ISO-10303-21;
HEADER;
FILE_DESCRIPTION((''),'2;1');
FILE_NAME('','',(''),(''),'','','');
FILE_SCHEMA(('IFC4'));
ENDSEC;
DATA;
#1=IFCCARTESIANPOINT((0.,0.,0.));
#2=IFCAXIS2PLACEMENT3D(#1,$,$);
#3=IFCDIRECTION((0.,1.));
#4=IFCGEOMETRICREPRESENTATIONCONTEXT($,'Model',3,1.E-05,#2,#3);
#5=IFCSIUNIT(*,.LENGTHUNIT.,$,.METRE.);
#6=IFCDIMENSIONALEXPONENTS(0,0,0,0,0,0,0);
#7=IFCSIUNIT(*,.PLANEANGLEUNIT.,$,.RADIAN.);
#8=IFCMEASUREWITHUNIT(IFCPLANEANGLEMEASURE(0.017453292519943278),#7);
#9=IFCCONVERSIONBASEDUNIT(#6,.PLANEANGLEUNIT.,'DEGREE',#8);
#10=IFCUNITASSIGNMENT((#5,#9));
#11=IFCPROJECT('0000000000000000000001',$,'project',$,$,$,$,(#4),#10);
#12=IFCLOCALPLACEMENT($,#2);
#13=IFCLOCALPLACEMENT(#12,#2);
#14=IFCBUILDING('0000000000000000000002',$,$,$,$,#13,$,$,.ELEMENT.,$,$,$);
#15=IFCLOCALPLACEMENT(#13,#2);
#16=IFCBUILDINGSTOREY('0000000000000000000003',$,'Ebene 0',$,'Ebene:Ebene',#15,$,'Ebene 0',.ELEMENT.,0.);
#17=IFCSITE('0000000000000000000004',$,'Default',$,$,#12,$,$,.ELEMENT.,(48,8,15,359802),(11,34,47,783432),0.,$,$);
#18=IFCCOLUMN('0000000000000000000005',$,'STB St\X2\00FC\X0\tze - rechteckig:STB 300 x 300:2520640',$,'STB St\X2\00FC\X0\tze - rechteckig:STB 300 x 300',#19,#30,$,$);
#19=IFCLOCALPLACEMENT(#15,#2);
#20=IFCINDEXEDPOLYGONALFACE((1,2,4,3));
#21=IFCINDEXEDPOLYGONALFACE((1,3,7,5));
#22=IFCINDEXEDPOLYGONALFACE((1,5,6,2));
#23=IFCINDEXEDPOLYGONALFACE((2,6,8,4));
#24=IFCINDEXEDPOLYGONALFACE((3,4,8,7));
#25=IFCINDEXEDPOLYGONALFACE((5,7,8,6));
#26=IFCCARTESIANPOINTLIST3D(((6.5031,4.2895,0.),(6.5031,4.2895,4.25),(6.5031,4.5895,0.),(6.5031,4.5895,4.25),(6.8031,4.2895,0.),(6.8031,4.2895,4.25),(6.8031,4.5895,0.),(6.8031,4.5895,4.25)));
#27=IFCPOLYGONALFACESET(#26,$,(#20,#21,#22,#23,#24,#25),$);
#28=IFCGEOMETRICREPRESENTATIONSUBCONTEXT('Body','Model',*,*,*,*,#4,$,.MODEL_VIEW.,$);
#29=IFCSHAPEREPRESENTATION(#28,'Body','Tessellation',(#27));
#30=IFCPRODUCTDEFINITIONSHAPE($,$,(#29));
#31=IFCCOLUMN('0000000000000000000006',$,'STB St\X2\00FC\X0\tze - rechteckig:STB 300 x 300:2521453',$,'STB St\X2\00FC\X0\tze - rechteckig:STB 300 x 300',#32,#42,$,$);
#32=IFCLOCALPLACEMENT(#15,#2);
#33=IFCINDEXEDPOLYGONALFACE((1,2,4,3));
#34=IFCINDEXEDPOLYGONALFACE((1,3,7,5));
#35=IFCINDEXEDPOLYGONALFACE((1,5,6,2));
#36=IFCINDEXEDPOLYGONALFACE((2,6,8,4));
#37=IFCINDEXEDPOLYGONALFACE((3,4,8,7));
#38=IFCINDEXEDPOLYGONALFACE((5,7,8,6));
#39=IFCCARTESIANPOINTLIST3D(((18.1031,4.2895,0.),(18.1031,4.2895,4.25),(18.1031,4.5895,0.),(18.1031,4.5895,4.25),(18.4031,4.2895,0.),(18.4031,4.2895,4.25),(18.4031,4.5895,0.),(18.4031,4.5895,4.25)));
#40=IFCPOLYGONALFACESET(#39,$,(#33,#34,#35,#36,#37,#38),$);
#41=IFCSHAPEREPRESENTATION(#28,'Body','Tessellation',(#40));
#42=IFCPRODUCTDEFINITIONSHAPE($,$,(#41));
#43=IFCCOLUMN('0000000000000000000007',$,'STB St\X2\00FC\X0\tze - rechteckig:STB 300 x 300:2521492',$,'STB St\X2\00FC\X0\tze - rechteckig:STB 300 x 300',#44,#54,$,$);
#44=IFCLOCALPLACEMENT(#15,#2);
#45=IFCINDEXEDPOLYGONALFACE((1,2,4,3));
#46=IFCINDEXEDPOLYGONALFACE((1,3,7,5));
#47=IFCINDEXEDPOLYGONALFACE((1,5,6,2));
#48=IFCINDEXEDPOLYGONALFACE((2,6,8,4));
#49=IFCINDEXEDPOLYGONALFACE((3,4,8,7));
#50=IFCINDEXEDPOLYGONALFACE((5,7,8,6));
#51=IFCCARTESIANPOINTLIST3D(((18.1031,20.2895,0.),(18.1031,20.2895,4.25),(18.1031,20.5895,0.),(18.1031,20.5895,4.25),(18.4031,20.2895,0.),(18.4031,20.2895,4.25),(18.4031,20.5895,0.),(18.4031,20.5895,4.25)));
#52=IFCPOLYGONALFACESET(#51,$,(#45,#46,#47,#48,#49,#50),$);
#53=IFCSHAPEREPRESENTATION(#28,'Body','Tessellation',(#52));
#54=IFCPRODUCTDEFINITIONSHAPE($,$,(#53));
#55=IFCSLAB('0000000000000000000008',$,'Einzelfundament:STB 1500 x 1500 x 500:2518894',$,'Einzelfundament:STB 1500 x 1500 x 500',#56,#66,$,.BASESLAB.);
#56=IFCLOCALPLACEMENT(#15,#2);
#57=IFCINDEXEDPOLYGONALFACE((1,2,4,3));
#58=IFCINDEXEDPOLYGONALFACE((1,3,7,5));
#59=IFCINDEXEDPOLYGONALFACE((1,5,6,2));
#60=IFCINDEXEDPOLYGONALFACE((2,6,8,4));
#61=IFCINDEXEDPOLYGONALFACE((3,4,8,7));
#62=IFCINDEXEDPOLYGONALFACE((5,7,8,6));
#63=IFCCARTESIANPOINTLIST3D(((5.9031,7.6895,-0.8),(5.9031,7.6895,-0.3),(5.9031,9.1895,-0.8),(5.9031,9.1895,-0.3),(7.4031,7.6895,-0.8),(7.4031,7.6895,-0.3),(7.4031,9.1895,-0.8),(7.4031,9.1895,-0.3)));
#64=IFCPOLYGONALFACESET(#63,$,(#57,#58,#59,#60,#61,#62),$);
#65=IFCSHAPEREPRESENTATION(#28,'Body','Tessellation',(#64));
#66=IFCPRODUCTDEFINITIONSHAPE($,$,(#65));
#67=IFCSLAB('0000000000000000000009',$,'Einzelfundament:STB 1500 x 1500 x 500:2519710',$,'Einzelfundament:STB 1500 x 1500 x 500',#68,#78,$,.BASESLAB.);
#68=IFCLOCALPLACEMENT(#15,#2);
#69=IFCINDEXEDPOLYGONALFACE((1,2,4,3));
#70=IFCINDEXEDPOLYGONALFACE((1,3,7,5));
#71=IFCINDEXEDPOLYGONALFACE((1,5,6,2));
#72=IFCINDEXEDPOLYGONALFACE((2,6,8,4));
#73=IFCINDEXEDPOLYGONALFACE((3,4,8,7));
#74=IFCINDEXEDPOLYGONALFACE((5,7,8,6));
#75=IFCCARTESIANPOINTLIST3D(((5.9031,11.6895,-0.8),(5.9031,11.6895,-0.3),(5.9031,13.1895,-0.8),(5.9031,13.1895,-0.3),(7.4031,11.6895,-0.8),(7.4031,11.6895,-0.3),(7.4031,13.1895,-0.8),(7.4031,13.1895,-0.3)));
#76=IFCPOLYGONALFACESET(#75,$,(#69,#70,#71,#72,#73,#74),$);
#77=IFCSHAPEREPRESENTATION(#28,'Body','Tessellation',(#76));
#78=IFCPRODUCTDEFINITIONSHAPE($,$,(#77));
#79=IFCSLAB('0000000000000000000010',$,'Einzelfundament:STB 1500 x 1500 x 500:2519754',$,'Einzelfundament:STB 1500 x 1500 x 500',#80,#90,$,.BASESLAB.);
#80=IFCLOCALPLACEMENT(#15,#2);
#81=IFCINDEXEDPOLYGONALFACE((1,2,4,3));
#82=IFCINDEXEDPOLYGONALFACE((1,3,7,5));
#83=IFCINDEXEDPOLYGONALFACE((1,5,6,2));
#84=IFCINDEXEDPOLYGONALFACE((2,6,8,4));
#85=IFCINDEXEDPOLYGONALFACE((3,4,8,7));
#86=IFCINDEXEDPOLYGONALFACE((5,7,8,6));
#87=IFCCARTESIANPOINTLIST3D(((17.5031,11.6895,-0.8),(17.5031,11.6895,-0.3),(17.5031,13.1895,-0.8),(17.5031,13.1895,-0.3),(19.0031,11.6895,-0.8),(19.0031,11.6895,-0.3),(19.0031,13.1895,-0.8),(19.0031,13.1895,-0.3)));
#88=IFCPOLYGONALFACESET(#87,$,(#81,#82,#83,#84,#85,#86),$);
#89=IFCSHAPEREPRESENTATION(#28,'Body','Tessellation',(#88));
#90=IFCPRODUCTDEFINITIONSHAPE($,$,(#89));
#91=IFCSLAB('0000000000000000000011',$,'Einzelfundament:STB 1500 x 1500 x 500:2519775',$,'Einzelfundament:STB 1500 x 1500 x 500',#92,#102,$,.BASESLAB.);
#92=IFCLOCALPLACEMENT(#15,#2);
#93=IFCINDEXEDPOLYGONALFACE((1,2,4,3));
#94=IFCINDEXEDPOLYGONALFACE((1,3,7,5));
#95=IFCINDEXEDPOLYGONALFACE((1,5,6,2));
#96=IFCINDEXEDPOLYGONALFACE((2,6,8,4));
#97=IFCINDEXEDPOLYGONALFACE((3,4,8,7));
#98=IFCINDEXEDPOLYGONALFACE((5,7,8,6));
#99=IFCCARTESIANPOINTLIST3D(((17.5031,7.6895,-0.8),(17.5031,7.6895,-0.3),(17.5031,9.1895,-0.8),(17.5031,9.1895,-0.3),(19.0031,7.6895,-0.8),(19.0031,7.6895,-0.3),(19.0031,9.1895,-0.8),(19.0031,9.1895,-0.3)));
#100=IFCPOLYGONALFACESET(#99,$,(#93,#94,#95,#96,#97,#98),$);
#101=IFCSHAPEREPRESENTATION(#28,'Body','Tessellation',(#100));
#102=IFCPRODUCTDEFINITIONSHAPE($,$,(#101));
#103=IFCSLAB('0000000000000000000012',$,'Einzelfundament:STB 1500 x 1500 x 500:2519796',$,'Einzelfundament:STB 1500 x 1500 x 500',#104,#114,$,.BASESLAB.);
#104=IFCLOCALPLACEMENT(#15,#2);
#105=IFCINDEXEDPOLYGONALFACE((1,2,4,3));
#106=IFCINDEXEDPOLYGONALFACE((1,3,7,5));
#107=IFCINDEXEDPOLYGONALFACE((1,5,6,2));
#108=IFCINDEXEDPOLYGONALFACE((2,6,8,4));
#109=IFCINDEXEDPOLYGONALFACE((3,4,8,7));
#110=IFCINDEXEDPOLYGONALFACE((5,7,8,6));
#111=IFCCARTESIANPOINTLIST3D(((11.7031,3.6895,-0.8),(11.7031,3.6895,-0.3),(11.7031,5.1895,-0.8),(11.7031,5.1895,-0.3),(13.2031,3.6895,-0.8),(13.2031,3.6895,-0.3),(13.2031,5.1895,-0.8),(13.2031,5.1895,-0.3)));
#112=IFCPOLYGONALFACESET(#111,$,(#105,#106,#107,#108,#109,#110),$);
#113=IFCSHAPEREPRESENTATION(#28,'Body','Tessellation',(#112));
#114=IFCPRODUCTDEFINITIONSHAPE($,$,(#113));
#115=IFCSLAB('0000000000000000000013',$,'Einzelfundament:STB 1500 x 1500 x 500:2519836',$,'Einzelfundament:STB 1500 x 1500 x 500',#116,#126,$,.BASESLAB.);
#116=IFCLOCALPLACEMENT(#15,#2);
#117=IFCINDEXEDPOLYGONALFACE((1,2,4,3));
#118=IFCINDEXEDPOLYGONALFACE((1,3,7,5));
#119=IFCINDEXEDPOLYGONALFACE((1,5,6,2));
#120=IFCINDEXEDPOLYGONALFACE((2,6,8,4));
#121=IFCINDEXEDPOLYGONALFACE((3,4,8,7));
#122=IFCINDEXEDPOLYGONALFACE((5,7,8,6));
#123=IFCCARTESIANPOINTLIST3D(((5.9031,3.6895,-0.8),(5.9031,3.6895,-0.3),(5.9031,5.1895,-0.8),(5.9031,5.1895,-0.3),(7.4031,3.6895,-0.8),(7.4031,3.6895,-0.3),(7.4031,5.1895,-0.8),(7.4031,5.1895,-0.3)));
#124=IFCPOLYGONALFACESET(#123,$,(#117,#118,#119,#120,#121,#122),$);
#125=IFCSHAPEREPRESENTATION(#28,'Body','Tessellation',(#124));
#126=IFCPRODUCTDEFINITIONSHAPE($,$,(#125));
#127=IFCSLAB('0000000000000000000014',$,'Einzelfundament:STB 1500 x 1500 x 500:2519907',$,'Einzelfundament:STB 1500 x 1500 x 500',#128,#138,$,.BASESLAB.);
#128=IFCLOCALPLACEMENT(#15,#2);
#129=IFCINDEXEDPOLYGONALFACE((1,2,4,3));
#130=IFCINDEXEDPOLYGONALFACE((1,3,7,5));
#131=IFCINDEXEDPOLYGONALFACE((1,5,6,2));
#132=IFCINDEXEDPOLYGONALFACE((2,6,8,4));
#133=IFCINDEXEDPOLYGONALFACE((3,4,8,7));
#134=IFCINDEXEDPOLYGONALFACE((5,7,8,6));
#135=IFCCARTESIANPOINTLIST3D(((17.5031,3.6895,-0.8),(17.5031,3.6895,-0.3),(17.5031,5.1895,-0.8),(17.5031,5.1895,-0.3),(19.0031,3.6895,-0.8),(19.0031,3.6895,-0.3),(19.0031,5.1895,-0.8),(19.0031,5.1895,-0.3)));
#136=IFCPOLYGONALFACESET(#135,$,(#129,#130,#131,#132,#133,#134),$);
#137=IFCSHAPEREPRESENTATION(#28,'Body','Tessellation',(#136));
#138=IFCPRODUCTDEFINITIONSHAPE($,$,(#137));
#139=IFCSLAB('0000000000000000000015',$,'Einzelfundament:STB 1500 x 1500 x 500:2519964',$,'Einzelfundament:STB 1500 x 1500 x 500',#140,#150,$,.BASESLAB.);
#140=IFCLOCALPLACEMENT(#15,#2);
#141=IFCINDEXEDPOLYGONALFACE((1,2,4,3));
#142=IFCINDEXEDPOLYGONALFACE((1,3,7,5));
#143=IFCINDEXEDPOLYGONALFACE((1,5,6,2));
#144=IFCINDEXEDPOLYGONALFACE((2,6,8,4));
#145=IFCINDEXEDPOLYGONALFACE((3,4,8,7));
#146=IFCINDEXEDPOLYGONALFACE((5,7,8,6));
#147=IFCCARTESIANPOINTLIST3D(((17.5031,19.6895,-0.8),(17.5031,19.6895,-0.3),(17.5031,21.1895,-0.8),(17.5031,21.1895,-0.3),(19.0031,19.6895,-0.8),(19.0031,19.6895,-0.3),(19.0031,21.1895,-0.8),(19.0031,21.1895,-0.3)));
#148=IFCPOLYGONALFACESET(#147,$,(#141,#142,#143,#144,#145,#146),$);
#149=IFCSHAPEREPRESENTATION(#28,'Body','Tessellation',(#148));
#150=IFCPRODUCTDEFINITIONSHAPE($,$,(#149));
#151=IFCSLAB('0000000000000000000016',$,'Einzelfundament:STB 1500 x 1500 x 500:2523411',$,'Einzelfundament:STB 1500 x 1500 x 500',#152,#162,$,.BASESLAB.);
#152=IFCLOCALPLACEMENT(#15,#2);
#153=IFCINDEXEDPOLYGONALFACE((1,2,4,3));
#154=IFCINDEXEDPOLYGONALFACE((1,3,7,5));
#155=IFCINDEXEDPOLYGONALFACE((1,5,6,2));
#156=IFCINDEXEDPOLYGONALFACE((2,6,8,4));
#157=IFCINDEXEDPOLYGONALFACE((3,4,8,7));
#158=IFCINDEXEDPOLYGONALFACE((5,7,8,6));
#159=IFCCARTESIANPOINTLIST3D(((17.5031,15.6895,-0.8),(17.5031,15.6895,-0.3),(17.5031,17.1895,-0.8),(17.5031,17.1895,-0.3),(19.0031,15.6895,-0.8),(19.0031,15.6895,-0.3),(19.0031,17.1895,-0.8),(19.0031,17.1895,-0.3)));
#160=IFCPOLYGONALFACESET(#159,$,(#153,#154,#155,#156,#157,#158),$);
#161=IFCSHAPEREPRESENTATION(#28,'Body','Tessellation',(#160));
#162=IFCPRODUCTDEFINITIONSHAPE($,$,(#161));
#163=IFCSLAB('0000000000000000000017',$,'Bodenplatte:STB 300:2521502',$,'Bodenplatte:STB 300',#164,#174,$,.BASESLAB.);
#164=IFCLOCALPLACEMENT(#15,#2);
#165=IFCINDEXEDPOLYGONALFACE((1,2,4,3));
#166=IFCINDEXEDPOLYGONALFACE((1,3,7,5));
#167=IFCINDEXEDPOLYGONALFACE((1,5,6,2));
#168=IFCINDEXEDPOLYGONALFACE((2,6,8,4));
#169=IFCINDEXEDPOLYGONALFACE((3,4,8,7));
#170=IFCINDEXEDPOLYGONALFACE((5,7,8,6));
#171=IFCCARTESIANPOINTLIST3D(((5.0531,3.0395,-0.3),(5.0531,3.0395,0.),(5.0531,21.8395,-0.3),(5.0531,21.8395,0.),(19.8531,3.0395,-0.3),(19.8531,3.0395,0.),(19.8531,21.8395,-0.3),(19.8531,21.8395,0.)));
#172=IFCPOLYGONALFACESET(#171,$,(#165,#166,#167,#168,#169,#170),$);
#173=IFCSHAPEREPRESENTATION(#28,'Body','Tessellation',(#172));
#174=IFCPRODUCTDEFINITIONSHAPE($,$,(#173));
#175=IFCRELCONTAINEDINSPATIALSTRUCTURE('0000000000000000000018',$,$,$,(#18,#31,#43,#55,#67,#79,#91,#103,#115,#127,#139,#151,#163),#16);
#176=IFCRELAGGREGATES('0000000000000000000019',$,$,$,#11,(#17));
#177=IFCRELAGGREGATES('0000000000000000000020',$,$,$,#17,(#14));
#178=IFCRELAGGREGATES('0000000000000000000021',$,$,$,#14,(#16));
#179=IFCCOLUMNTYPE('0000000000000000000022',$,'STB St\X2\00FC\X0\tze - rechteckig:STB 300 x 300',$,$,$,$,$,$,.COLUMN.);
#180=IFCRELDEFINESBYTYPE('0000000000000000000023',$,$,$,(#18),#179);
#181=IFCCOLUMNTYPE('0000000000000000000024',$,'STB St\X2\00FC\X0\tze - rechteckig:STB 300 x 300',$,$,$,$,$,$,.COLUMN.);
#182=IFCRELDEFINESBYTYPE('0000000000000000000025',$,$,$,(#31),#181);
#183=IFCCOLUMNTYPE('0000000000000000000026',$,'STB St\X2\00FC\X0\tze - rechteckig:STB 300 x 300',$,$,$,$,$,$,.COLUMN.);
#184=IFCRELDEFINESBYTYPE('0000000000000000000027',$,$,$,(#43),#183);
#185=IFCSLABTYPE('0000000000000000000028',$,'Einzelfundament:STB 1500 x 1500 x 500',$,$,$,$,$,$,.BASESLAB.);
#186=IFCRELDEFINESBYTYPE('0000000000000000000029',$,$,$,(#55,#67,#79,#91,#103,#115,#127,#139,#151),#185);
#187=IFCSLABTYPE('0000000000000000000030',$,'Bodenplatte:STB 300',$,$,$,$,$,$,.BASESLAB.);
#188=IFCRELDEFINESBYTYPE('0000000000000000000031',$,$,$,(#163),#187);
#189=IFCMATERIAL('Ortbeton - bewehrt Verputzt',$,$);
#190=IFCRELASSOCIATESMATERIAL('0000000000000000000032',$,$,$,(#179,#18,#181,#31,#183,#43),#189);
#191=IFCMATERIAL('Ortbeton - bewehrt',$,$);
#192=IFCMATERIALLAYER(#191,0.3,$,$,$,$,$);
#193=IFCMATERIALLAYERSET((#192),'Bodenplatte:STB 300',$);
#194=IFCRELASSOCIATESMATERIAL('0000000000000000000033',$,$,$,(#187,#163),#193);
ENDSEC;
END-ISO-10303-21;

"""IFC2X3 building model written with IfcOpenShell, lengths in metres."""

from ifc_helpers import new_model, entity, si_unit, converted_unit, direction, frame, frame_2d, origin, origin_2d_with_axis, place, context, subcontext, project, spatial, rectangle, extrude, source, transform, mapped, material, layer, layer_set, layer_usage, type_object, type_shapes, element, save


model = new_model("IFC2X3")

# Units and contexts
model_context = context("Model", 3, precision=1e-05, world=origin(), true_north=direction((0.0, 1.0)))
body_context = subcontext(model_context, "Body", "Model", "MODEL_VIEW")
ifc_project = project(units=[si_unit("LENGTHUNIT", "METRE"), converted_unit("PLANEANGLEUNIT", "DEGREE", entity("IfcPlaneAngleMeasure", 0.017453292519943278), si_unit("PLANEANGLEUNIT", "RADIAN"), dimensions=[0, 0, 0, 0, 0, 0, 0])], contexts=[model_context])

# Site, building, storey
site_placement = place(None, origin())
site = spatial("IfcSite", under=ifc_project, at=site_placement, Name="Default", CompositionType="ELEMENT", RefLatitude=(48, 8, 15, 359802), RefLongitude=(11, 34, 47, 783432), RefElevation=0.0)
building_placement = place(site_placement, origin())
building = spatial("IfcBuilding", under=site, at=building_placement, CompositionType="ELEMENT")
storey_placement = place(building_placement, origin())
storey = spatial("IfcBuildingStorey", under=building, at=storey_placement, Name="Ebene 0", ObjectType="Ebene:Ebene", LongName="Ebene 0", CompositionType="ELEMENT", Elevation=0.0)

# Columns
ifc_material_1 = material(Name="Ortbeton - bewehrt Verputzt")
column_type_1 = type_object("IfcColumnType", Name="STB Stütze - rechteckig:STB 300 x 300", PredefinedType="COLUMN", material=ifc_material_1)
shared_shape_1 = source(origin(), body_context, "Body", "SweptSolid", [
    extrude(rectangle(XDim=0.3, YDim=0.3, at=frame_2d((0.0, 0.0), x_axis=(1.0, 0.0))), frame((6.6531, 4.4395, 0.0), z_axis=(0.0, 0.0, 1.0), x_axis=(-1.0, 0.0, 0.0)), (0.0, 0.0, 1.0), 4.25),
])
type_shapes(column_type_1, [shared_shape_1])
column_1_placement = place(storey_placement, origin())
element("IfcColumn", 1, at=column_1_placement, inside=storey, type_object=column_type_1, material=ifc_material_1, Name="STB Stütze - rechteckig:STB 300 x 300:2520640", ObjectType="STB Stütze - rechteckig:STB 300 x 300", context=body_context, shape_type="MappedRepresentation", body=[
    mapped(shared_shape_1, transform((0.0, 0.0, 0.0), scale=1.0)),
])
column_type_2 = type_object("IfcColumnType", Name="STB Stütze - rechteckig:STB 300 x 300", PredefinedType="COLUMN", material=ifc_material_1)
shared_shape_2 = source(origin(), body_context, "Body", "SweptSolid", [
    extrude(rectangle(XDim=0.3, YDim=0.3, at=frame_2d((0.0, 0.0), x_axis=(1.0, 0.0))), frame((18.2531, 4.4395, 0.0), z_axis=(0.0, 0.0, 1.0), x_axis=(-1.0, 0.0, 0.0)), (0.0, 0.0, 1.0), 4.25),
])
type_shapes(column_type_2, [shared_shape_2])
column_2_placement = place(storey_placement, origin())
element("IfcColumn", 2, at=column_2_placement, inside=storey, type_object=column_type_2, material=ifc_material_1, Name="STB Stütze - rechteckig:STB 300 x 300:2521453", ObjectType="STB Stütze - rechteckig:STB 300 x 300", context=body_context, shape_type="MappedRepresentation", body=[
    mapped(shared_shape_2, transform((0.0, 0.0, 0.0), scale=1.0)),
])
column_type_3 = type_object("IfcColumnType", Name="STB Stütze - rechteckig:STB 300 x 300", PredefinedType="COLUMN", material=ifc_material_1)
shared_shape_3 = source(origin(), body_context, "Body", "SweptSolid", [
    extrude(rectangle(XDim=0.3, YDim=0.3, at=frame_2d((0.0, 0.0), x_axis=(1.0, 0.0))), frame((18.2531, 20.4395, 0.0), z_axis=(0.0, 0.0, 1.0), x_axis=(-1.0, 0.0, 0.0)), (0.0, 0.0, 1.0), 4.25),
])
type_shapes(column_type_3, [shared_shape_3])
column_3_placement = place(storey_placement, origin())
element("IfcColumn", 3, at=column_3_placement, inside=storey, type_object=column_type_3, material=ifc_material_1, Name="STB Stütze - rechteckig:STB 300 x 300:2521492", ObjectType="STB Stütze - rechteckig:STB 300 x 300", context=body_context, shape_type="MappedRepresentation", body=[
    mapped(shared_shape_3, transform((0.0, 0.0, 0.0), scale=1.0)),
])

# Slabs
slab_type_1 = type_object("IfcSlabType", Name="Einzelfundament:STB 1500 x 1500 x 500", PredefinedType="BASESLAB")
slab_1_placement = place(storey_placement, origin())
element("IfcSlab", 4, at=slab_1_placement, inside=storey, type_object=slab_type_1, Name="Einzelfundament:STB 1500 x 1500 x 500:2518894", ObjectType="Einzelfundament:STB 1500 x 1500 x 500", PredefinedType="BASESLAB", context=body_context, shape_type="SweptSolid", body=[
    extrude(rectangle(XDim=1.5, YDim=1.5, at=frame_2d((0.0, 0.0), x_axis=(1.0, 0.0))), frame((6.6531, 8.4395, -0.8), z_axis=(0.0, 0.0, 1.0), x_axis=(-1.0, 0.0, 0.0)), (0.0, 0.0, 1.0), 0.5),
])
slab_2_placement = place(storey_placement, origin())
element("IfcSlab", 5, at=slab_2_placement, inside=storey, type_object=slab_type_1, Name="Einzelfundament:STB 1500 x 1500 x 500:2519710", ObjectType="Einzelfundament:STB 1500 x 1500 x 500", PredefinedType="BASESLAB", context=body_context, shape_type="SweptSolid", body=[
    extrude(rectangle(XDim=1.5, YDim=1.5, at=frame_2d((0.0, 0.0), x_axis=(1.0, 0.0))), frame((6.6531, 12.4395, -0.8), z_axis=(0.0, 0.0, 1.0), x_axis=(-1.0, 0.0, 0.0)), (0.0, 0.0, 1.0), 0.5),
])
slab_3_placement = place(storey_placement, origin())
element("IfcSlab", 6, at=slab_3_placement, inside=storey, type_object=slab_type_1, Name="Einzelfundament:STB 1500 x 1500 x 500:2519754", ObjectType="Einzelfundament:STB 1500 x 1500 x 500", PredefinedType="BASESLAB", context=body_context, shape_type="SweptSolid", body=[
    extrude(rectangle(XDim=1.5, YDim=1.5, at=frame_2d((0.0, 0.0), x_axis=(1.0, 0.0))), frame((18.2531, 12.4395, -0.8), z_axis=(0.0, 0.0, 1.0), x_axis=(-1.0, 0.0, 0.0)), (0.0, 0.0, 1.0), 0.5),
])
slab_4_placement = place(storey_placement, origin())
element("IfcSlab", 7, at=slab_4_placement, inside=storey, type_object=slab_type_1, Name="Einzelfundament:STB 1500 x 1500 x 500:2519775", ObjectType="Einzelfundament:STB 1500 x 1500 x 500", PredefinedType="BASESLAB", context=body_context, shape_type="SweptSolid", body=[
    extrude(rectangle(XDim=1.5, YDim=1.5, at=frame_2d((0.0, 0.0), x_axis=(1.0, 0.0))), frame((18.2531, 8.4395, -0.8), z_axis=(0.0, 0.0, 1.0), x_axis=(-1.0, 0.0, 0.0)), (0.0, 0.0, 1.0), 0.5),
])
slab_5_placement = place(storey_placement, origin())
element("IfcSlab", 8, at=slab_5_placement, inside=storey, type_object=slab_type_1, Name="Einzelfundament:STB 1500 x 1500 x 500:2519796", ObjectType="Einzelfundament:STB 1500 x 1500 x 500", PredefinedType="BASESLAB", context=body_context, shape_type="SweptSolid", body=[
    extrude(rectangle(XDim=1.5, YDim=1.5, at=frame_2d((0.0, 0.0), x_axis=(1.0, 0.0))), frame((12.4531, 4.4395, -0.8), z_axis=(0.0, 0.0, 1.0), x_axis=(0.0, 1.0, 0.0)), (0.0, 0.0, 1.0), 0.5),
])
slab_6_placement = place(storey_placement, origin())
element("IfcSlab", 9, at=slab_6_placement, inside=storey, type_object=slab_type_1, Name="Einzelfundament:STB 1500 x 1500 x 500:2519836", ObjectType="Einzelfundament:STB 1500 x 1500 x 500", PredefinedType="BASESLAB", context=body_context, shape_type="SweptSolid", body=[
    extrude(rectangle(XDim=1.5, YDim=1.5, at=frame_2d((0.0, 0.0), x_axis=(1.0, 0.0))), frame((6.6531, 4.4395, -0.8), z_axis=(0.0, 0.0, 1.0), x_axis=(-1.0, 0.0, 0.0)), (0.0, 0.0, 1.0), 0.5),
])
slab_7_placement = place(storey_placement, origin())
element("IfcSlab", 10, at=slab_7_placement, inside=storey, type_object=slab_type_1, Name="Einzelfundament:STB 1500 x 1500 x 500:2519907", ObjectType="Einzelfundament:STB 1500 x 1500 x 500", PredefinedType="BASESLAB", context=body_context, shape_type="SweptSolid", body=[
    extrude(rectangle(XDim=1.5, YDim=1.5, at=frame_2d((0.0, 0.0), x_axis=(1.0, 0.0))), frame((18.2531, 4.4395, -0.8), z_axis=(0.0, 0.0, 1.0), x_axis=(-1.0, 0.0, 0.0)), (0.0, 0.0, 1.0), 0.5),
])
slab_8_placement = place(storey_placement, origin())
element("IfcSlab", 11, at=slab_8_placement, inside=storey, type_object=slab_type_1, Name="Einzelfundament:STB 1500 x 1500 x 500:2519964", ObjectType="Einzelfundament:STB 1500 x 1500 x 500", PredefinedType="BASESLAB", context=body_context, shape_type="SweptSolid", body=[
    extrude(rectangle(XDim=1.5, YDim=1.5, at=frame_2d((0.0, 0.0), x_axis=(1.0, 0.0))), frame((18.2531, 20.4395, -0.8), z_axis=(0.0, 0.0, 1.0), x_axis=(-1.0, 0.0, 0.0)), (0.0, 0.0, 1.0), 0.5),
])
slab_9_placement = place(storey_placement, origin())
element("IfcSlab", 12, at=slab_9_placement, inside=storey, type_object=slab_type_1, Name="Einzelfundament:STB 1500 x 1500 x 500:2523411", ObjectType="Einzelfundament:STB 1500 x 1500 x 500", PredefinedType="BASESLAB", context=body_context, shape_type="SweptSolid", body=[
    extrude(rectangle(XDim=1.5, YDim=1.5, at=frame_2d((0.0, 0.0), x_axis=(1.0, 0.0))), frame((18.2531, 16.4395, -0.8), z_axis=(0.0, 0.0, 1.0), x_axis=(-1.0, 0.0, 0.0)), (0.0, 0.0, 1.0), 0.5),
])
ifc_material_2 = material(Name="Ortbeton - bewehrt")
ifc_layer = layer(ifc_material_2, 0.3)
ifc_layer_set = layer_set([ifc_layer], Name="Bodenplatte:STB 300")
ifc_layer_usage = layer_usage(ifc_layer_set, "AXIS3", "POSITIVE", 0.0)
slab_type_2 = type_object("IfcSlabType", Name="Bodenplatte:STB 300", PredefinedType="BASESLAB", material=ifc_layer_set)
slab_10_placement = place(storey_placement, origin())
element("IfcSlab", 13, at=slab_10_placement, inside=storey, type_object=slab_type_2, material=ifc_layer_usage, Name="Bodenplatte:STB 300:2521502", ObjectType="Bodenplatte:STB 300", PredefinedType="BASESLAB", context=body_context, shape_type="SweptSolid", body=[
    extrude(rectangle(XDim=18.8, YDim=14.8, at=origin_2d_with_axis()), frame((12.4531, 12.4395, 0.0), z_axis=(0.0, 0.0, -1.0), x_axis=(0.0, 1.0, 0.0)), (0.0, 0.0, 1.0), 0.3),
])

save(model, "model.ifc")
